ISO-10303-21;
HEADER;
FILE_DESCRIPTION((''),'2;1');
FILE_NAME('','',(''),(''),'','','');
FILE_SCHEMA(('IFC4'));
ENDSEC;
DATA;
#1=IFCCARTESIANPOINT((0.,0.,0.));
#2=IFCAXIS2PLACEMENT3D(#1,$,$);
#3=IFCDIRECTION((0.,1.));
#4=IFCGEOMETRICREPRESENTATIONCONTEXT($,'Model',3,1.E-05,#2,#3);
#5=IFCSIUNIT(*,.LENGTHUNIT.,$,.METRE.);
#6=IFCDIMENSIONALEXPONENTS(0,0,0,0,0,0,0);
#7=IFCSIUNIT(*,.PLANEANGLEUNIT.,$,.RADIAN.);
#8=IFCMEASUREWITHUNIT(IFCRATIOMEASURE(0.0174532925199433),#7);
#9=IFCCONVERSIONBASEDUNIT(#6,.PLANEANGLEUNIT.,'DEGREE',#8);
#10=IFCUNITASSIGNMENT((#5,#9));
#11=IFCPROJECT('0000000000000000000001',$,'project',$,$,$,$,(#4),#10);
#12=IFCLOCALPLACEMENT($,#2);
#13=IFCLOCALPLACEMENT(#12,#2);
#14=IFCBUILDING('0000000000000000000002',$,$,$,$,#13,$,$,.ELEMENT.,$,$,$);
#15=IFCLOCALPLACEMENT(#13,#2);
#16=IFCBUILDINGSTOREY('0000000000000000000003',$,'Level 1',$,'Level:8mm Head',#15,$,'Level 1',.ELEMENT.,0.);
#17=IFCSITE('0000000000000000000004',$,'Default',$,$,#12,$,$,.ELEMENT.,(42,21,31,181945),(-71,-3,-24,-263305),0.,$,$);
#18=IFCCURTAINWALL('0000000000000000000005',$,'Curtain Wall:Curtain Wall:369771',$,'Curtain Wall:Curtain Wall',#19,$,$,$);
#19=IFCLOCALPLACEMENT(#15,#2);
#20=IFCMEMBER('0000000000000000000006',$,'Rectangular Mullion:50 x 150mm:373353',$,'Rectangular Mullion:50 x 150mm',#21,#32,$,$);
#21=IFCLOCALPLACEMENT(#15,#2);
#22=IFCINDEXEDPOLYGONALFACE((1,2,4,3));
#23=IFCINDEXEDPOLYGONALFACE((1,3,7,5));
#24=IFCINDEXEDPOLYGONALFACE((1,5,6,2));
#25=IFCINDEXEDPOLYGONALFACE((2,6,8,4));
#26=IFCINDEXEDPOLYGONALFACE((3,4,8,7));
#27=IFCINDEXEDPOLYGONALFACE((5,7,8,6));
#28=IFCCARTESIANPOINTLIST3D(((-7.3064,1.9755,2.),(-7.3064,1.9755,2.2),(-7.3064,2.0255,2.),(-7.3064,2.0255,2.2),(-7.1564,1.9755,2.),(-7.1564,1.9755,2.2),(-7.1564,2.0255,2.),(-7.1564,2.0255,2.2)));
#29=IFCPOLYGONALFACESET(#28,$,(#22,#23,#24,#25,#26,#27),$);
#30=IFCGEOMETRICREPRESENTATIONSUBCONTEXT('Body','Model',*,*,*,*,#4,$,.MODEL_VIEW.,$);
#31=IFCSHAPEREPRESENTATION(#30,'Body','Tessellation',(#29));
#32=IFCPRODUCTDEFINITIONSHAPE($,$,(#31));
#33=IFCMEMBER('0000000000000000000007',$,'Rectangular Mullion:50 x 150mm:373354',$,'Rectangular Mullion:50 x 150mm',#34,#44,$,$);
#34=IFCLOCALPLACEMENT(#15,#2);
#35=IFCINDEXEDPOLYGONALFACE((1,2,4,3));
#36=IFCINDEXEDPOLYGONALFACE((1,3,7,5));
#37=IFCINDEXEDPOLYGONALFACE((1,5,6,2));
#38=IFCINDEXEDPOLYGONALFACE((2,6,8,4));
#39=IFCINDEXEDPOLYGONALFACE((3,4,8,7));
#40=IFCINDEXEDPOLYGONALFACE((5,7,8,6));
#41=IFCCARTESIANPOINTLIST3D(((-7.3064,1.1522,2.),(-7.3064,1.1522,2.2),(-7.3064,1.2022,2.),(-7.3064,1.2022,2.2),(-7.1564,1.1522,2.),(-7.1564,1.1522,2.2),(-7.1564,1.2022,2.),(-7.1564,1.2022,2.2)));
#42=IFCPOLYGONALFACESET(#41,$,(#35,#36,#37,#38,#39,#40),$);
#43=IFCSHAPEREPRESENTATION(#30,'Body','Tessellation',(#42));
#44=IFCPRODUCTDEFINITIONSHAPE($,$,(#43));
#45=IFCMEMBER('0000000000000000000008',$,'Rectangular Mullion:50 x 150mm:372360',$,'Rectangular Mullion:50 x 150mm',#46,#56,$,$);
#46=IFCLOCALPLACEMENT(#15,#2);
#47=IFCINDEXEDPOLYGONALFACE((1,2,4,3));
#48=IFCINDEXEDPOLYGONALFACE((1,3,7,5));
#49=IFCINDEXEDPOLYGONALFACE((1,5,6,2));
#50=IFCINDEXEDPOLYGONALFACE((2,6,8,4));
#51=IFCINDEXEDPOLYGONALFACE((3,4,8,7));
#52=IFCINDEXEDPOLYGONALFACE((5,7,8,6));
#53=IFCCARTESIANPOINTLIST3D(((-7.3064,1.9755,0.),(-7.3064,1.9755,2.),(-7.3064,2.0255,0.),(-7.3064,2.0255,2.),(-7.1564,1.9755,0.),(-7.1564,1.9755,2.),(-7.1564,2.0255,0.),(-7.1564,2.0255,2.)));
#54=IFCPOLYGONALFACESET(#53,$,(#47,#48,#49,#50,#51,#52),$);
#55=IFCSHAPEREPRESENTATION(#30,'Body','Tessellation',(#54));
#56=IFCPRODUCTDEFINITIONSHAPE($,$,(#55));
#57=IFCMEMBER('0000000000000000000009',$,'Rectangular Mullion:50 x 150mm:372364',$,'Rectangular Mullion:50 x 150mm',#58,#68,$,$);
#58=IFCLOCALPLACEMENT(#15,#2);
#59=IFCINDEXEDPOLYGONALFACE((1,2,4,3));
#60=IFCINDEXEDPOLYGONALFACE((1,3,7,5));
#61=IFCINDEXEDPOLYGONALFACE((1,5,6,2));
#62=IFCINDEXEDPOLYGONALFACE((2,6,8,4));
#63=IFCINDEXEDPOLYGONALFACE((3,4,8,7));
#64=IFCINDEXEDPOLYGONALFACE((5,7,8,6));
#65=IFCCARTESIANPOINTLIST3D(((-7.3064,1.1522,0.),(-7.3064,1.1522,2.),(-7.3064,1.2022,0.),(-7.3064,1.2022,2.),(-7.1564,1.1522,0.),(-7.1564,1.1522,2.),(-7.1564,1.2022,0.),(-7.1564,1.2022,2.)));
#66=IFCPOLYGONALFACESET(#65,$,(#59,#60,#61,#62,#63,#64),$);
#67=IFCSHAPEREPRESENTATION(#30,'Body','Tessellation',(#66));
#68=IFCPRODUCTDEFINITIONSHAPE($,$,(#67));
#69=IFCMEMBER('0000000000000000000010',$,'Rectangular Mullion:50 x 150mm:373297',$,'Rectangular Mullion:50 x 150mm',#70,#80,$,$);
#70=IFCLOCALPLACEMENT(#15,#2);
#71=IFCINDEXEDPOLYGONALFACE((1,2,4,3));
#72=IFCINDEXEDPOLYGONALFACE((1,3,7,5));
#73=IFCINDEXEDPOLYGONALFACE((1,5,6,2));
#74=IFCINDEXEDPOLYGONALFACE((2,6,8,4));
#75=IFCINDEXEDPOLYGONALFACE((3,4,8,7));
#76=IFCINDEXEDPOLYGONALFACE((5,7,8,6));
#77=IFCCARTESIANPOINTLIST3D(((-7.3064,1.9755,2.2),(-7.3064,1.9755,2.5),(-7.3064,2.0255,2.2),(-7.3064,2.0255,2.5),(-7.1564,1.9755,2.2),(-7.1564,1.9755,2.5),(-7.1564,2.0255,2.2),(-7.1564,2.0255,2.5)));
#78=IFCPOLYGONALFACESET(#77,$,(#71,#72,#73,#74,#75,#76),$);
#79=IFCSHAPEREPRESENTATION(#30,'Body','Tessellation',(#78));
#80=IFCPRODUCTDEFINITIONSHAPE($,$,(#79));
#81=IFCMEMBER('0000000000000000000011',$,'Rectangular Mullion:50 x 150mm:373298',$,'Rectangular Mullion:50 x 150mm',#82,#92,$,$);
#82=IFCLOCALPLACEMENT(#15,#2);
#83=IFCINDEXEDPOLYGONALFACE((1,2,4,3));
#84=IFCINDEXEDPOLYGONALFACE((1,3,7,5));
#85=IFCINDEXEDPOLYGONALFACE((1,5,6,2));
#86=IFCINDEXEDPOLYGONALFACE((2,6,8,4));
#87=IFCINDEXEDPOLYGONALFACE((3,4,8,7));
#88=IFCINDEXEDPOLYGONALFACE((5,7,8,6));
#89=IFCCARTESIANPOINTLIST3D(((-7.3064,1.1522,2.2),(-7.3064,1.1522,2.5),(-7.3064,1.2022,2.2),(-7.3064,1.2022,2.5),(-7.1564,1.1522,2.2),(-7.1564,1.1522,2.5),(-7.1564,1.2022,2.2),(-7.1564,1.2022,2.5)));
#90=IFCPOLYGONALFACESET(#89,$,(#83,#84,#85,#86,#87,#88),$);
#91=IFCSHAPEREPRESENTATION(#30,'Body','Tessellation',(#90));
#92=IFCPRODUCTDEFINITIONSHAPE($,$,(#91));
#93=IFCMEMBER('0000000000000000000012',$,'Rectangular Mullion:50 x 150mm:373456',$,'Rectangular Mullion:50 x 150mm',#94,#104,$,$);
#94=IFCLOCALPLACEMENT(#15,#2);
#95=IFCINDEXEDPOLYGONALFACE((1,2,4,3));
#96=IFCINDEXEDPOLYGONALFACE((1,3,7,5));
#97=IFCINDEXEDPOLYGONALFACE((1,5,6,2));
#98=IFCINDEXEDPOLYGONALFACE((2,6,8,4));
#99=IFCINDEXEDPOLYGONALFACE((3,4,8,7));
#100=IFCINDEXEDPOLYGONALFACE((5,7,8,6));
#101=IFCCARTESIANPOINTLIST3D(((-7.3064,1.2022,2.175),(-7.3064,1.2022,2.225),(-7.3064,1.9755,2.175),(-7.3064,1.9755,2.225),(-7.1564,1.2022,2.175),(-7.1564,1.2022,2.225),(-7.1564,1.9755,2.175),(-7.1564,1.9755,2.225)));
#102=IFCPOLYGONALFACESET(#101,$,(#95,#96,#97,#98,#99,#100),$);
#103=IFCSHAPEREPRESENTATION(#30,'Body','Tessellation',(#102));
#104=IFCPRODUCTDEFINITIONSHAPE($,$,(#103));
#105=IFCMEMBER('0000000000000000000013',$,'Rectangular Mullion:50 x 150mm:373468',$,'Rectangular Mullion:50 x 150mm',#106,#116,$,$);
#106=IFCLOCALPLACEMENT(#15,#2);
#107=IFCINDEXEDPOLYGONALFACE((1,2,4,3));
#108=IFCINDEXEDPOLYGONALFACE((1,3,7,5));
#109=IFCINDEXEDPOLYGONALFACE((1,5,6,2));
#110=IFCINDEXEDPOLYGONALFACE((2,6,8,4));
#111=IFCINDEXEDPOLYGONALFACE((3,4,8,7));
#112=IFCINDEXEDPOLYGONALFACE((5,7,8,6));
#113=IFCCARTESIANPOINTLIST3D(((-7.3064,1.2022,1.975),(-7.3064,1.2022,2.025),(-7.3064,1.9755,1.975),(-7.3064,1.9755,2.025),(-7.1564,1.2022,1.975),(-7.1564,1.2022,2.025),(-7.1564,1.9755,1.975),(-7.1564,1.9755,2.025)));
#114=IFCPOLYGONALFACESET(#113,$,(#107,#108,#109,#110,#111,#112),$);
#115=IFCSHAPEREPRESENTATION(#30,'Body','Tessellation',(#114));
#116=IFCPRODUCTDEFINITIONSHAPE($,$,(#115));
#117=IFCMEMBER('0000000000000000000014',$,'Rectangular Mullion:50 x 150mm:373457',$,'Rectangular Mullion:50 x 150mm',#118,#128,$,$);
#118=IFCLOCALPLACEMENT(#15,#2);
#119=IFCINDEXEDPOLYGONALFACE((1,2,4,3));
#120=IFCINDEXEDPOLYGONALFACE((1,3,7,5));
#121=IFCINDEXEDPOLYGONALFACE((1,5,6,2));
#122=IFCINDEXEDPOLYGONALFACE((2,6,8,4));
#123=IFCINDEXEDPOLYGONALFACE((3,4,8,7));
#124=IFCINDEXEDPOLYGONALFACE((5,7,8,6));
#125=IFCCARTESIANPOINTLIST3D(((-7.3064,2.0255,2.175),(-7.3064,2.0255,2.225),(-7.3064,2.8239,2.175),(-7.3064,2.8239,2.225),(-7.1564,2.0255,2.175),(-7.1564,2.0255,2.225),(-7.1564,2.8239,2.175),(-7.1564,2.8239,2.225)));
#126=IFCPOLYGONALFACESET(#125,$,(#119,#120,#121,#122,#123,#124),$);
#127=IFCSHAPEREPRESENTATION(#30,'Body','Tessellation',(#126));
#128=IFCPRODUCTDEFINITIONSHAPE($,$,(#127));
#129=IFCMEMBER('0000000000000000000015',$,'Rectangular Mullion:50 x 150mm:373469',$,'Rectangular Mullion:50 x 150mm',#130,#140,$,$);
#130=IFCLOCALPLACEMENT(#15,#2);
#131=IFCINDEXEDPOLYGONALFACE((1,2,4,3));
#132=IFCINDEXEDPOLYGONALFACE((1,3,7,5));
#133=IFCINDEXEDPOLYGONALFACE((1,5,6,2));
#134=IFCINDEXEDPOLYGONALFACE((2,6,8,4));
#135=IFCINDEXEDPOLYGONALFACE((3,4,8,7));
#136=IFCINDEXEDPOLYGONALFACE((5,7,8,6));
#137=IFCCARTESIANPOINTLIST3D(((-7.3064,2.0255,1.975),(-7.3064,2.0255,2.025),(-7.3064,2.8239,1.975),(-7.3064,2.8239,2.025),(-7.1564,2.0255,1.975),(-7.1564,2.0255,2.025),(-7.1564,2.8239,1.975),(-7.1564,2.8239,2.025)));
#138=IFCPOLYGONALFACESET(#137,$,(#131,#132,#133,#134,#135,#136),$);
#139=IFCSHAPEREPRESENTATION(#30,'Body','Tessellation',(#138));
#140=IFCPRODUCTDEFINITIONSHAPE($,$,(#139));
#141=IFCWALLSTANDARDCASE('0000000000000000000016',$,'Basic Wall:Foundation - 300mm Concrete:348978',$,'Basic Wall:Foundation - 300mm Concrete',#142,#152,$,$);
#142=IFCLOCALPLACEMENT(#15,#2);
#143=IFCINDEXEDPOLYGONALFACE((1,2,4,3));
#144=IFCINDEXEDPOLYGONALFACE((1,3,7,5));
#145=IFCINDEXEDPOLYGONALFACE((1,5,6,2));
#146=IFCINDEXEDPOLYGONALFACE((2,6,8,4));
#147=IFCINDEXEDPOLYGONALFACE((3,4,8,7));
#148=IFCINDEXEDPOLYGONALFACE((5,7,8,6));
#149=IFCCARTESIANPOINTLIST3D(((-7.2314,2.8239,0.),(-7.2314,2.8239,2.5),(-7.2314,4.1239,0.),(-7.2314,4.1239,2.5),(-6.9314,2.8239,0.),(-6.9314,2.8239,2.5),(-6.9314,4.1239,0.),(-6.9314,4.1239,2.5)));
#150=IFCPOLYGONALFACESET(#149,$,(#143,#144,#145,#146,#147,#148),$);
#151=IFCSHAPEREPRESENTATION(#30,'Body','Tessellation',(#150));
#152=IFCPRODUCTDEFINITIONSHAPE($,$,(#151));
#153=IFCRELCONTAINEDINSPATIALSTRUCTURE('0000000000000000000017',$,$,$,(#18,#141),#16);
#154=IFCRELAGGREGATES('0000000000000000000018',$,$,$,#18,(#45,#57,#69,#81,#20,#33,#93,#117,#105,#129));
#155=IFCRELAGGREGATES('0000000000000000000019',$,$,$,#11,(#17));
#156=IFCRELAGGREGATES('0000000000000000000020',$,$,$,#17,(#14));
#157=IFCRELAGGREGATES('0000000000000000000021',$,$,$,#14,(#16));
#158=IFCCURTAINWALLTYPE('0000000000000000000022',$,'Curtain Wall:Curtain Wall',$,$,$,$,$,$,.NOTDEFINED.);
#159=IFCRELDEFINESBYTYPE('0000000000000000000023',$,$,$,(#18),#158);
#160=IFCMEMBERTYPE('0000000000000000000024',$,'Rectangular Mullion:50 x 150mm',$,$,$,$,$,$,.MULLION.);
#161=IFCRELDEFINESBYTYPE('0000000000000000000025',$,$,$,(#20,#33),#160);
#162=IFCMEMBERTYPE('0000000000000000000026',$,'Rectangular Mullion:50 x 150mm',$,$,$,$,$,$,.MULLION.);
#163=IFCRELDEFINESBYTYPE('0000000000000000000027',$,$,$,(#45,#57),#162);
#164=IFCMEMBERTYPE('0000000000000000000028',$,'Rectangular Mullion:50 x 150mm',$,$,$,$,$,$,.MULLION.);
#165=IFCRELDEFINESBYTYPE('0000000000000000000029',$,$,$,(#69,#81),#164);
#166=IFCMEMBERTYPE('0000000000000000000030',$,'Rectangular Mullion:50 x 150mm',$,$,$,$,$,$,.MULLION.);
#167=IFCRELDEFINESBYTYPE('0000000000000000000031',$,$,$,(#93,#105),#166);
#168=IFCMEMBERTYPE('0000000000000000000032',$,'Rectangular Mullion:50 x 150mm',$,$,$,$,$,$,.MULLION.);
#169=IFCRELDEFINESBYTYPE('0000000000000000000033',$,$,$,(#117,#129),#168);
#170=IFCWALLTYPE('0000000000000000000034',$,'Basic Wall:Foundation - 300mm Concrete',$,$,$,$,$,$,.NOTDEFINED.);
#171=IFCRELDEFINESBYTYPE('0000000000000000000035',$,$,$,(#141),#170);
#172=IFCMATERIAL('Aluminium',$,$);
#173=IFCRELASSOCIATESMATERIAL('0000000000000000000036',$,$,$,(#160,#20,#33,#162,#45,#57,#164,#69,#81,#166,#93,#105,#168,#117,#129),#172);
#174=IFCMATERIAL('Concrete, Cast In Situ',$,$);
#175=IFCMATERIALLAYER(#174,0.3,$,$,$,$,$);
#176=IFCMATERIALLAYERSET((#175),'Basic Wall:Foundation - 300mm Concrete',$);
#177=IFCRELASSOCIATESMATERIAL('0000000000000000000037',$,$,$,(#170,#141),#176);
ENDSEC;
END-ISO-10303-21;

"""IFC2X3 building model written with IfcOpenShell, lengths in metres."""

from ifc_helpers import new_model, entity, si_unit, converted_unit, direction, frame, frame_2d, origin, origin_2d_with_axis, place, context, subcontext, project, spatial, rectangle, extrude, source, transform, mapped, material, layer, layer_set, layer_usage, type_object, type_shapes, element, aggregate, save


model = new_model("IFC2X3")

# Units and contexts
model_context = context("Model", 3, precision=1e-05, world=origin(), true_north=direction((0.0, 1.0)))
body_context = subcontext(model_context, "Body", "Model", "MODEL_VIEW")
ifc_project = project(units=[si_unit("LENGTHUNIT", "METRE"), converted_unit("PLANEANGLEUNIT", "DEGREE", entity("IfcRatioMeasure", 0.0174532925199433), si_unit("PLANEANGLEUNIT", "RADIAN"), dimensions=[0, 0, 0, 0, 0, 0, 0])], contexts=[model_context])

# Site, building, storey
site_placement = place(None, origin())
site = spatial("IfcSite", under=ifc_project, at=site_placement, Name="Default", CompositionType="ELEMENT", RefLatitude=(42, 21, 31, 181945), RefLongitude=(-71, -3, -24, -263305), RefElevation=0.0)
building_placement = place(site_placement, origin())
building = spatial("IfcBuilding", under=site, at=building_placement, CompositionType="ELEMENT")
storey_placement = place(building_placement, origin())
storey = spatial("IfcBuildingStorey", under=building, at=storey_placement, Name="Level 1", ObjectType="Level:8mm Head", LongName="Level 1", CompositionType="ELEMENT", Elevation=0.0)

# Curtain wall, members
curtain_wall_type = type_object("IfcCurtainWallType", Name="Curtain Wall:Curtain Wall", PredefinedType="NOTDEFINED")
curtain_wall_placement = place(storey_placement, origin())
curtain_wall = element("IfcCurtainWall", 1, at=curtain_wall_placement, inside=storey, type_object=curtain_wall_type, Name="Curtain Wall:Curtain Wall:369771", ObjectType="Curtain Wall:Curtain Wall")
ifc_material_1 = material(Name="Aluminium")
member_type_1 = type_object("IfcMemberType", Name="Rectangular Mullion:50 x 150mm", PredefinedType="MULLION", material=ifc_material_1)
shared_shape_1 = source(origin(), body_context, "Body", "SweptSolid", [
    extrude(rectangle(XDim=0.15, YDim=0.05, at=origin_2d_with_axis()), frame((0.0, 0.0, -0.2), z_axis=(0.0, 0.0, 1.0), x_axis=(0.0, -1.0, 0.0)), (0.0, 0.0, 1.0), 0.2),
])
type_shapes(member_type_1, [shared_shape_1])
member_1_placement = place(storey_placement, frame((-7.2314, 2.0005, 2.0), z_axis=(0.0, 0.0, -1.0), x_axis=(0.0, -1.0, 0.0)))
member_1 = element("IfcMember", 2, at=member_1_placement, type_object=member_type_1, material=ifc_material_1, Name="Rectangular Mullion:50 x 150mm:373353", ObjectType="Rectangular Mullion:50 x 150mm", context=body_context, shape_type="MappedRepresentation", body=[
    mapped(shared_shape_1, transform((0.0, 0.0, 0.0), scale=1.0)),
])
member_2_placement = place(storey_placement, frame((-7.2314, 1.1772, 2.0), z_axis=(0.0, 0.0, -1.0), x_axis=(0.0, -1.0, 0.0)))
member_2 = element("IfcMember", 3, at=member_2_placement, type_object=member_type_1, material=ifc_material_1, Name="Rectangular Mullion:50 x 150mm:373354", ObjectType="Rectangular Mullion:50 x 150mm", context=body_context, shape_type="MappedRepresentation", body=[
    mapped(shared_shape_1, transform((0.0, 0.0, 0.0), scale=1.0)),
])
member_type_2 = type_object("IfcMemberType", Name="Rectangular Mullion:50 x 150mm", PredefinedType="MULLION", material=ifc_material_1)
shared_shape_2 = source(origin(), body_context, "Body", "SweptSolid", [
    extrude(rectangle(XDim=0.15, YDim=0.05, at=origin_2d_with_axis()), frame((0.0, 0.0, -2.0), z_axis=(0.0, 0.0, 1.0), x_axis=(0.0, -1.0, 0.0)), (0.0, 0.0, 1.0), 2.0),
])
type_shapes(member_type_2, [shared_shape_2])
member_3_placement = place(storey_placement, frame((-7.2314, 2.0005, 0.0), z_axis=(0.0, 0.0, -1.0), x_axis=(0.0, -1.0, 0.0)))
member_3 = element("IfcMember", 4, at=member_3_placement, type_object=member_type_2, material=ifc_material_1, Name="Rectangular Mullion:50 x 150mm:372360", ObjectType="Rectangular Mullion:50 x 150mm", context=body_context, shape_type="MappedRepresentation", body=[
    mapped(shared_shape_2, transform((0.0, 0.0, 0.0), scale=1.0)),
])
member_4_placement = place(storey_placement, frame((-7.2314, 1.1772, 0.0), z_axis=(0.0, 0.0, -1.0), x_axis=(0.0, -1.0, 0.0)))
member_4 = element("IfcMember", 5, at=member_4_placement, type_object=member_type_2, material=ifc_material_1, Name="Rectangular Mullion:50 x 150mm:372364", ObjectType="Rectangular Mullion:50 x 150mm", context=body_context, shape_type="MappedRepresentation", body=[
    mapped(shared_shape_2, transform((0.0, 0.0, 0.0), scale=1.0)),
])
member_type_3 = type_object("IfcMemberType", Name="Rectangular Mullion:50 x 150mm", PredefinedType="MULLION", material=ifc_material_1)
shared_shape_3 = source(origin(), body_context, "Body", "SweptSolid", [
    extrude(rectangle(XDim=0.15, YDim=0.05, at=origin_2d_with_axis()), frame((0.0, 0.0, -0.3), z_axis=(0.0, 0.0, 1.0), x_axis=(0.0, -1.0, 0.0)), (0.0, 0.0, 1.0), 0.3),
])
type_shapes(member_type_3, [shared_shape_3])
member_5_placement = place(storey_placement, frame((-7.2314, 2.0005, 2.2), z_axis=(0.0, 0.0, -1.0), x_axis=(0.0, -1.0, 0.0)))
member_5 = element("IfcMember", 6, at=member_5_placement, type_object=member_type_3, material=ifc_material_1, Name="Rectangular Mullion:50 x 150mm:373297", ObjectType="Rectangular Mullion:50 x 150mm", context=body_context, shape_type="MappedRepresentation", body=[
    mapped(shared_shape_3, transform((0.0, 0.0, 0.0), scale=1.0)),
])
member_6_placement = place(storey_placement, frame((-7.2314, 1.1772, 2.2), z_axis=(0.0, 0.0, -1.0), x_axis=(0.0, -1.0, 0.0)))
member_6 = element("IfcMember", 7, at=member_6_placement, type_object=member_type_3, material=ifc_material_1, Name="Rectangular Mullion:50 x 150mm:373298", ObjectType="Rectangular Mullion:50 x 150mm", context=body_context, shape_type="MappedRepresentation", body=[
    mapped(shared_shape_3, transform((0.0, 0.0, 0.0), scale=1.0)),
])
member_type_4 = type_object("IfcMemberType", Name="Rectangular Mullion:50 x 150mm", PredefinedType="MULLION", material=ifc_material_1)
shared_shape_4 = source(origin(), body_context, "Body", "SweptSolid", [
    extrude(rectangle(XDim=0.15, YDim=0.05, at=origin_2d_with_axis()), frame((0.0, 0.0, -0.7733), z_axis=(0.0, 0.0, 1.0), x_axis=(0.0, -1.0, 0.0)), (0.0, 0.0, 1.0), 0.7733),
])
type_shapes(member_type_4, [shared_shape_4])
member_7_placement = place(storey_placement, frame((-7.2314, 1.2022, 2.2), z_axis=(0.0, -1.0, 0.0), x_axis=(0.0, 0.0, 1.0)))
member_7 = element("IfcMember", 8, at=member_7_placement, type_object=member_type_4, material=ifc_material_1, Name="Rectangular Mullion:50 x 150mm:373456", ObjectType="Rectangular Mullion:50 x 150mm", context=body_context, shape_type="MappedRepresentation", body=[
    mapped(shared_shape_4, transform((0.0, 0.0, 0.0), scale=1.0)),
])
member_8_placement = place(storey_placement, frame((-7.2314, 1.2022, 2.0), z_axis=(0.0, -1.0, 0.0), x_axis=(0.0, 0.0, 1.0)))
member_8 = element("IfcMember", 9, at=member_8_placement, type_object=member_type_4, material=ifc_material_1, Name="Rectangular Mullion:50 x 150mm:373468", ObjectType="Rectangular Mullion:50 x 150mm", context=body_context, shape_type="MappedRepresentation", body=[
    mapped(shared_shape_4, transform((0.0, 0.0, 0.0), scale=1.0)),
])
member_type_5 = type_object("IfcMemberType", Name="Rectangular Mullion:50 x 150mm", PredefinedType="MULLION", material=ifc_material_1)
shared_shape_5 = source(origin(), body_context, "Body", "SweptSolid", [
    extrude(rectangle(XDim=0.15, YDim=0.05, at=origin_2d_with_axis()), frame((0.0, 0.0, -0.7983), z_axis=(0.0, 0.0, 1.0), x_axis=(0.0, -1.0, 0.0)), (0.0, 0.0, 1.0), 0.7983),
])
type_shapes(member_type_5, [shared_shape_5])
member_9_placement = place(storey_placement, frame((-7.2314, 2.0255, 2.2), z_axis=(0.0, -1.0, 0.0), x_axis=(0.0, 0.0, 1.0)))
member_9 = element("IfcMember", 10, at=member_9_placement, type_object=member_type_5, material=ifc_material_1, Name="Rectangular Mullion:50 x 150mm:373457", ObjectType="Rectangular Mullion:50 x 150mm", context=body_context, shape_type="MappedRepresentation", body=[
    mapped(shared_shape_5, transform((0.0, 0.0, 0.0), scale=1.0)),
])
member_10_placement = place(storey_placement, frame((-7.2314, 2.0255, 2.0), z_axis=(0.0, -1.0, 0.0), x_axis=(0.0, 0.0, 1.0)))
member_10 = element("IfcMember", 11, at=member_10_placement, type_object=member_type_5, material=ifc_material_1, Name="Rectangular Mullion:50 x 150mm:373469", ObjectType="Rectangular Mullion:50 x 150mm", context=body_context, shape_type="MappedRepresentation", body=[
    mapped(shared_shape_5, transform((0.0, 0.0, 0.0), scale=1.0)),
])
aggregate(curtain_wall, [member_3, member_4, member_5, member_6, member_1, member_2, member_7, member_9, member_8, member_10])

# Wall
ifc_material_2 = material(Name="Concrete, Cast In Situ")
ifc_layer = layer(ifc_material_2, 0.3)
ifc_layer_set = layer_set([ifc_layer], Name="Basic Wall:Foundation - 300mm Concrete")
ifc_layer_usage_1 = layer_usage(ifc_layer_set, "AXIS2", "NEGATIVE", 0.15)
wall_type = type_object("IfcWallType", Name="Basic Wall:Foundation - 300mm Concrete", PredefinedType="NOTDEFINED", material=ifc_layer_set)
wall_1_placement = place(storey_placement, frame((-7.0814, 2.8239, 0.0), z_axis=(0.0, 0.0, 1.0), x_axis=(0.0, 1.0, 0.0)))
element("IfcWallStandardCase", 12, at=wall_1_placement, inside=storey, type_object=wall_type, material=ifc_layer_usage_1, Name="Basic Wall:Foundation - 300mm Concrete:348978", ObjectType="Basic Wall:Foundation - 300mm Concrete", context=body_context, shape_type="SweptSolid", body=[
    extrude(rectangle(XDim=1.3, YDim=0.3, at=frame_2d((0.65, 0.0), x_axis=(-1.0, 0.0))), origin(), (0.0, 0.0, 1.0), 2.5),
])

save(model, "model.ifc")
